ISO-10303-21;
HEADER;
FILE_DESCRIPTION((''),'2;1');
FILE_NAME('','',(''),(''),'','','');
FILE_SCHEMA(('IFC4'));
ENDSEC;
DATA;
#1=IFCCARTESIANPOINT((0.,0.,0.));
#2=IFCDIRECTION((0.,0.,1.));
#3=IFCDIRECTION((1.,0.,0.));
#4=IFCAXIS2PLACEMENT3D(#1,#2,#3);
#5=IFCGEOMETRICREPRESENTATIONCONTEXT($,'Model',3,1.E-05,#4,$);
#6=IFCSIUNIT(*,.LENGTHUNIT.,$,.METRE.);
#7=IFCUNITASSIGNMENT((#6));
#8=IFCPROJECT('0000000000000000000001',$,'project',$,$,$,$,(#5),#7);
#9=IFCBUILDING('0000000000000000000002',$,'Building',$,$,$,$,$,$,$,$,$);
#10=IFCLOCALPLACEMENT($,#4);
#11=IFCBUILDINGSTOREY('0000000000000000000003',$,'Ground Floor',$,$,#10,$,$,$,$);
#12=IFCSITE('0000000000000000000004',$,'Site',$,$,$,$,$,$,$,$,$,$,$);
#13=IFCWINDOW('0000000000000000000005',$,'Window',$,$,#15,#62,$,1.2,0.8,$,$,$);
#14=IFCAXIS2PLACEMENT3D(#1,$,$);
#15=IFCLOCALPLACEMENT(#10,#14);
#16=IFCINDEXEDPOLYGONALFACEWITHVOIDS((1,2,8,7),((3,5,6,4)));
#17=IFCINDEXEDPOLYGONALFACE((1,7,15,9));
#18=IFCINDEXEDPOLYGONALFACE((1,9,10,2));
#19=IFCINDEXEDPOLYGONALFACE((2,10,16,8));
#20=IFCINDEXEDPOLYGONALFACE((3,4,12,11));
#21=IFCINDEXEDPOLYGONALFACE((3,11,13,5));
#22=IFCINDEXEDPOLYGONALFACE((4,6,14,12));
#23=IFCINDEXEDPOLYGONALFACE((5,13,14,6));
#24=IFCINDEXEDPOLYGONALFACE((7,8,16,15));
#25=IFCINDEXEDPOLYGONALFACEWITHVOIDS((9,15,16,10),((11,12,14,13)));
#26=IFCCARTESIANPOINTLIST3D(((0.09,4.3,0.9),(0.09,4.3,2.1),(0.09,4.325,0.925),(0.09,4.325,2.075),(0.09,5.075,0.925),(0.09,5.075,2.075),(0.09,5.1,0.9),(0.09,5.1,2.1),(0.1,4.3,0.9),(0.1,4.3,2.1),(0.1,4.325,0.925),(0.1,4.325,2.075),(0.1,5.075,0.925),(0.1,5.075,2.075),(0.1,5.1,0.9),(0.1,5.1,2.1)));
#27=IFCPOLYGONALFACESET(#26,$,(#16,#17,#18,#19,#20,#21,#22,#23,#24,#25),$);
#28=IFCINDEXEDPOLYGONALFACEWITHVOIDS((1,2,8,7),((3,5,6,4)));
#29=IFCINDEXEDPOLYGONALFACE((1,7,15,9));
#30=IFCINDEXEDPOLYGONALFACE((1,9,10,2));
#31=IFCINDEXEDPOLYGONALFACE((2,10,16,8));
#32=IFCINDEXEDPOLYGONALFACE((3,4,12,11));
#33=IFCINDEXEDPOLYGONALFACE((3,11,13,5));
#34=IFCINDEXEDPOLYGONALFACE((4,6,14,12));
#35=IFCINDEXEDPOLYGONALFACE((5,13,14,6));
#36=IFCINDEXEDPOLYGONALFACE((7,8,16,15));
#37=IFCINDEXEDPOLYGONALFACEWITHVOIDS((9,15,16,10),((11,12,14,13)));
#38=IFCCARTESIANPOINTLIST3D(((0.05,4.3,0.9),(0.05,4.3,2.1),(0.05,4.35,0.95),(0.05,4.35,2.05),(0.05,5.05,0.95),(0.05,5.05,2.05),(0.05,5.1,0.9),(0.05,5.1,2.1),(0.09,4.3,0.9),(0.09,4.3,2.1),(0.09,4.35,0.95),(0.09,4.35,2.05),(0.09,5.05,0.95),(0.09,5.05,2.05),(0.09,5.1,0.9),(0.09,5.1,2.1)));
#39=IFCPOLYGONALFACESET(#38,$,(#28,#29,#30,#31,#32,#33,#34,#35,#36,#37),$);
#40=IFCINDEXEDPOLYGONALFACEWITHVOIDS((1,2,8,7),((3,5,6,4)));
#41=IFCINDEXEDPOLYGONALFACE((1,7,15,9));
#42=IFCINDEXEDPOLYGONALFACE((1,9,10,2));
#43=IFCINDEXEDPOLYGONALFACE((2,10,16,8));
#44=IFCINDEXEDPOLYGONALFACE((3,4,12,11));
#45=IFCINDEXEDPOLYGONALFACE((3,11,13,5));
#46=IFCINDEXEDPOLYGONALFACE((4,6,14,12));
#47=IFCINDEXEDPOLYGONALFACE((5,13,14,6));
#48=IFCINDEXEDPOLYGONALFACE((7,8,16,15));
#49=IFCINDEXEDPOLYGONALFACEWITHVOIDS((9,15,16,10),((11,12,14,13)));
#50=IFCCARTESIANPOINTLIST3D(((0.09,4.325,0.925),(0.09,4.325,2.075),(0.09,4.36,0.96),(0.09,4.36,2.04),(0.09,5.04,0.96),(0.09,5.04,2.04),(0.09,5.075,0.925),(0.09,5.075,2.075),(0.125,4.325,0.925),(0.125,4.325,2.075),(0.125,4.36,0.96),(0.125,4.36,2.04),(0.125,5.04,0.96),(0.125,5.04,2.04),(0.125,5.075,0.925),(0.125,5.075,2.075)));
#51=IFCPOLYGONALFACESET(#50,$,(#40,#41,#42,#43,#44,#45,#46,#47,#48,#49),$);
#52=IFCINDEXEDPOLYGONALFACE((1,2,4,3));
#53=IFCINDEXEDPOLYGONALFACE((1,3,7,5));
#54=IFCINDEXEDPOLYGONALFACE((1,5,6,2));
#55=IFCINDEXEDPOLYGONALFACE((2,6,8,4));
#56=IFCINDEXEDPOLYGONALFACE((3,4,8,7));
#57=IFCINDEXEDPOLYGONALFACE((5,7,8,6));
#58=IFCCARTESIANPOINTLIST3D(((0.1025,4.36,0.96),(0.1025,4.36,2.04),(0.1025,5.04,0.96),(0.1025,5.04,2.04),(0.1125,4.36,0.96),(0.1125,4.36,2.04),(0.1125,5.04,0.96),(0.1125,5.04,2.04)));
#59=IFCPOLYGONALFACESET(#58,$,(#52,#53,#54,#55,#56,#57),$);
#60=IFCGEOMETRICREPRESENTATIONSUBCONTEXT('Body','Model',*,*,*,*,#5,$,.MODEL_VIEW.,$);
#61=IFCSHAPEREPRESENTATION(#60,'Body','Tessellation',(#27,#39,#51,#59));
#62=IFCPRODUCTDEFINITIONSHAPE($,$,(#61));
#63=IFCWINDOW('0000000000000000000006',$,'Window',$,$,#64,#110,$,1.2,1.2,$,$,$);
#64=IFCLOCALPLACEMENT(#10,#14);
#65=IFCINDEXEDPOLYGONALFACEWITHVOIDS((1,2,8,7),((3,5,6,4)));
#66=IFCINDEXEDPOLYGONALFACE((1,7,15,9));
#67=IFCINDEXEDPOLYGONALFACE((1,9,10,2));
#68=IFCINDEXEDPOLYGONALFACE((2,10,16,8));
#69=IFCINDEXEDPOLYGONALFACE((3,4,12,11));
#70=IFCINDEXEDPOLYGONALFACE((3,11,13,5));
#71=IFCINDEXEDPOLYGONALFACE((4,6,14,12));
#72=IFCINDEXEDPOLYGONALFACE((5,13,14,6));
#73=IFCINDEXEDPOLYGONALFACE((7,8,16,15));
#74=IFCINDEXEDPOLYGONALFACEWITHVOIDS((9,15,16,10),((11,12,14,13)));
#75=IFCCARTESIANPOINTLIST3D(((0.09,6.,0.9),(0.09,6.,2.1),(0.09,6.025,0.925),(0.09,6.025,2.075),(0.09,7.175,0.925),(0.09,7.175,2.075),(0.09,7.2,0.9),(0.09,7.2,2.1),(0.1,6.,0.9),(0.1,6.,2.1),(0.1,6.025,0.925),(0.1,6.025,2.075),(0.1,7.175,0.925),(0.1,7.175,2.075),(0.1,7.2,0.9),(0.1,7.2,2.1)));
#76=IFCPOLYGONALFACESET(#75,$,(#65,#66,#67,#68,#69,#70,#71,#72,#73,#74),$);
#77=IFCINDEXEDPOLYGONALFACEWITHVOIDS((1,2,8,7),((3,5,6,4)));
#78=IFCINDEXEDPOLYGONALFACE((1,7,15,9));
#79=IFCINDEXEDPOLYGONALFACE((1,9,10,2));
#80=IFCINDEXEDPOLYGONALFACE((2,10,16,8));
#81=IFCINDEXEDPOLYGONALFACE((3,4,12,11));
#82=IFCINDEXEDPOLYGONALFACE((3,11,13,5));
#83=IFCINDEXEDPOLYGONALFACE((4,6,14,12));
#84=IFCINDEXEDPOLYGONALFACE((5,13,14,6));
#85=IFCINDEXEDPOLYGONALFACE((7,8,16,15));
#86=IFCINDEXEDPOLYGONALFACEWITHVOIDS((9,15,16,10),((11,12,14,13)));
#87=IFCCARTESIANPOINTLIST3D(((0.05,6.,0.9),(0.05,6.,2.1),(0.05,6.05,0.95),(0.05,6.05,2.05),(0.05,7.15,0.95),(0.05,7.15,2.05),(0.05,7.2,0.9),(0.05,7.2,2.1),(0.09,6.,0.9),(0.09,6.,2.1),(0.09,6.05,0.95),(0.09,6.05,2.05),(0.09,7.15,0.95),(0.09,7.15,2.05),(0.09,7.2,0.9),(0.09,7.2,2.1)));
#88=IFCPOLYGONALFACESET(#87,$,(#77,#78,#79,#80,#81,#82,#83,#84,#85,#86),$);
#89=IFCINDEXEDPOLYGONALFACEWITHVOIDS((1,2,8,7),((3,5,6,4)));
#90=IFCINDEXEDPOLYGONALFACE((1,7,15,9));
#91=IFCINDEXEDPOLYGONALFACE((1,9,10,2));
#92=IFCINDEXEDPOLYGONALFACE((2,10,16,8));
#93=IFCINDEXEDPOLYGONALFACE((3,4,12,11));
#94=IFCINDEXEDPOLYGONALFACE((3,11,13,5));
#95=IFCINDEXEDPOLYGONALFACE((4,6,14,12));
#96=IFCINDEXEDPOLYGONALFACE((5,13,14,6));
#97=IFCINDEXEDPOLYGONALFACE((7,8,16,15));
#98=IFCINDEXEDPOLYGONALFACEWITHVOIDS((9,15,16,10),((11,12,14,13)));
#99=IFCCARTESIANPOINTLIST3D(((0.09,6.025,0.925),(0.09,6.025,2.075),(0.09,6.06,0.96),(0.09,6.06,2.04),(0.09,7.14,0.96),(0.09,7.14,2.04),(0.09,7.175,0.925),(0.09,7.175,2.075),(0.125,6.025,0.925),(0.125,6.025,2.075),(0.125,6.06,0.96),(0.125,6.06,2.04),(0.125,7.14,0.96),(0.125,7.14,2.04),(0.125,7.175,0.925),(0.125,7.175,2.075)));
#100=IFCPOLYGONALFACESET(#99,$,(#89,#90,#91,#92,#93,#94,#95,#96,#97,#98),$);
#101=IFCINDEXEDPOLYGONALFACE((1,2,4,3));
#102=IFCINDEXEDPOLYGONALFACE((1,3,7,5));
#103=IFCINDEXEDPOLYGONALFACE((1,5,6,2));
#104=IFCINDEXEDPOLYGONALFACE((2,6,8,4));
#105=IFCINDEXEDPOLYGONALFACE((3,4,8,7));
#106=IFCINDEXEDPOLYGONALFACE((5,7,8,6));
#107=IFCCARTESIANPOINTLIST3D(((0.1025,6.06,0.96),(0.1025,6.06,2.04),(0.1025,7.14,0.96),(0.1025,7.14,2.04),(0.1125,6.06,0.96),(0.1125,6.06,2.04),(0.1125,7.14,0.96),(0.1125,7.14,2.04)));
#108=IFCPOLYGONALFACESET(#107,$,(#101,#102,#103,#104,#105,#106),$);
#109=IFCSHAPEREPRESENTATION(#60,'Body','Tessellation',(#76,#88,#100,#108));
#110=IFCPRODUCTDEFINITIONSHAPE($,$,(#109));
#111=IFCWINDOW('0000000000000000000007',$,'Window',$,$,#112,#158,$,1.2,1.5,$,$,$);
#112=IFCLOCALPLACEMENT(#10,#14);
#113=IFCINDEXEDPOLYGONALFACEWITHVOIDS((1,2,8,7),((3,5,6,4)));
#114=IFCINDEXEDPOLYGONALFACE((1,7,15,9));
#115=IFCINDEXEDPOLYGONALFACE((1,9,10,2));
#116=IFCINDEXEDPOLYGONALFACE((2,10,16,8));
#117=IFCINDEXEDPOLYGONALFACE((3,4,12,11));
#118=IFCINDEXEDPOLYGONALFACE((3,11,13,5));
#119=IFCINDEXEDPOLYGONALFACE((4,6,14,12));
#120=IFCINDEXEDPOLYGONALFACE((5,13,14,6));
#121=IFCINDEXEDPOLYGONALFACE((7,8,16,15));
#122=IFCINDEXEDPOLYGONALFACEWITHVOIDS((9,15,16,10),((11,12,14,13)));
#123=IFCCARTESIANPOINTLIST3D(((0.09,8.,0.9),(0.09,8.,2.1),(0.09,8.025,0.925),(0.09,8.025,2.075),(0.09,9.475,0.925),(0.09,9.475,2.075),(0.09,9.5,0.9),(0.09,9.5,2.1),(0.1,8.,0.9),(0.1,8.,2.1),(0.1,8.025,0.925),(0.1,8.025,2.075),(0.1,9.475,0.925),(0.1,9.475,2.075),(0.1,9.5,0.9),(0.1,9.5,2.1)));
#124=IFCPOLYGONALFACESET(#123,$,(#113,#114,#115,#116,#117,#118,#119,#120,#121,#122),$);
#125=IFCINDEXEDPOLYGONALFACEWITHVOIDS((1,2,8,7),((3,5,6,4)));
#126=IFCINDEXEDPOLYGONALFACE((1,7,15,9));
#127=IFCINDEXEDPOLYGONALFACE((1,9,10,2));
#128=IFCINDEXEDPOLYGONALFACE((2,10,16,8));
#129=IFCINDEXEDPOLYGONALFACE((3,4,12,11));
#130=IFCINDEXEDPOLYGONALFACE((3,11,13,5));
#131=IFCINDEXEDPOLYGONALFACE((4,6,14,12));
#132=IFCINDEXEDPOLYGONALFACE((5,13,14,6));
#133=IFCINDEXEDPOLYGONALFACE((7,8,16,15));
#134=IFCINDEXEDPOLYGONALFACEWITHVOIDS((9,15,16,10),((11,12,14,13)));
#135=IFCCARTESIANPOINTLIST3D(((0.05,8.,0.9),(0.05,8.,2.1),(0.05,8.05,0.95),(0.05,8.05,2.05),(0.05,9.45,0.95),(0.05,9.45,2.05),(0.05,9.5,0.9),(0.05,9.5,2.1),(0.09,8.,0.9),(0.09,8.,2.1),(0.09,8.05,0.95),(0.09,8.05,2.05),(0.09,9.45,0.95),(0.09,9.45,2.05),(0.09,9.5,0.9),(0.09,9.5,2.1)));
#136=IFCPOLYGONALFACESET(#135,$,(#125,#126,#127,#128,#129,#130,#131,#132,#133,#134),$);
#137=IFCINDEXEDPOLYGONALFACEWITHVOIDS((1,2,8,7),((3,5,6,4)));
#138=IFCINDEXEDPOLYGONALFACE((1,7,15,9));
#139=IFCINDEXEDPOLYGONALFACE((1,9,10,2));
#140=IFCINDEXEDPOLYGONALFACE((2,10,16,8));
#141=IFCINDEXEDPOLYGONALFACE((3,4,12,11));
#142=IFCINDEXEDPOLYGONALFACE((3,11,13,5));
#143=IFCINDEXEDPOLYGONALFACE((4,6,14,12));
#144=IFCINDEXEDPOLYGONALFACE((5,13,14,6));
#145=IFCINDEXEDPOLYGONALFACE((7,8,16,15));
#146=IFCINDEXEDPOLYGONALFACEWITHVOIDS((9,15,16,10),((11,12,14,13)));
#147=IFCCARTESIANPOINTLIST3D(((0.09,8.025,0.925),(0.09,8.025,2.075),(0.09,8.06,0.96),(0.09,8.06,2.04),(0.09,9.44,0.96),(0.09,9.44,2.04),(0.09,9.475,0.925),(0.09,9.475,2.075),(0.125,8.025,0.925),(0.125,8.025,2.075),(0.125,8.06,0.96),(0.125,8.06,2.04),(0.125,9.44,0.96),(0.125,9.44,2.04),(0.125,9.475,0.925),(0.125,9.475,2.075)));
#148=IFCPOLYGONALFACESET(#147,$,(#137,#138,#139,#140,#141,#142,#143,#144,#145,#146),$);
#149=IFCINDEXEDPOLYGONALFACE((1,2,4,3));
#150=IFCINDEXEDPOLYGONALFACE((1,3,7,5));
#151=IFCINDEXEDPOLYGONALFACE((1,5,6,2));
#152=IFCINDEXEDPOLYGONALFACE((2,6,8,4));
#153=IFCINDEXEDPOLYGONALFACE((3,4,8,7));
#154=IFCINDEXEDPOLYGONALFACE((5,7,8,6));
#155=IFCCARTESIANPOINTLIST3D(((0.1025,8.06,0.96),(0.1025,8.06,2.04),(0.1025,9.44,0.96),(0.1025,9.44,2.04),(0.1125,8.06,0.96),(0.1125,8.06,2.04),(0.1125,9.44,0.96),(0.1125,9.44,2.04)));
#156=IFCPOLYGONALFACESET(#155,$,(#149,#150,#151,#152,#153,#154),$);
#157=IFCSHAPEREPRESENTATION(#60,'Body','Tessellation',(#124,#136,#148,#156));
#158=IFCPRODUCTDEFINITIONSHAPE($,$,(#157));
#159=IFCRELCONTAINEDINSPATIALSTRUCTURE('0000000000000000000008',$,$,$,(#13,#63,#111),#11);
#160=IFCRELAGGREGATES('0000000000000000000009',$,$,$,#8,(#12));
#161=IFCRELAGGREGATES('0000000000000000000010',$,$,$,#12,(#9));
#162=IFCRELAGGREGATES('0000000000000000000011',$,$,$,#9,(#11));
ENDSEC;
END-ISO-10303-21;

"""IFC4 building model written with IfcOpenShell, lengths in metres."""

from ifc_helpers import new_model, si_unit, frame, origin_with_axes, place, context, subcontext, project, spatial, line, indexed_curve, outline, extrude, element, save


model = new_model("IFC4")

# Units and contexts
model_context = context("Model", 3, precision=1e-05, world=origin_with_axes())
body_context = subcontext(model_context, "Body", "Model", "MODEL_VIEW")
ifc_project = project(units=[si_unit("LENGTHUNIT", "METRE")], contexts=[model_context])

# Site, building, storey
site = spatial("IfcSite", under=ifc_project, Name="Site")
building = spatial("IfcBuilding", under=site, Name="Building")
storey_placement = place(None, origin_with_axes())
storey = spatial("IfcBuildingStorey", under=building, at=storey_placement, Name="Ground Floor")

# Windows
window_1_placement = place(storey_placement, frame((0.0, 5.1, 0.9), z_axis=(0.0, 0.0, 1.0), x_axis=(0.0, -1.0, 0.0)))
element("IfcWindow", 1, at=window_1_placement, inside=storey, Name="Window", OverallHeight=1.2, OverallWidth=0.8, context=body_context, shape_type="SweptSolid", body=[
    extrude(outline(indexed_curve([(0.0, 0.0), (0.8, 0.0), (0.8, 1.2), (0.0, 1.2)], segments=[line(1, 2, 3, 4, 1)]), holes=[indexed_curve([(0.025, 0.025), (0.775, 0.025), (0.775, 1.175), (0.025, 1.175)], segments=[line(1, 2, 3, 4, 1)])]), frame((0.0, 0.09, 0.0), z_axis=(0.0, -1.0, 0.0), x_axis=(1.0, 0.0, 0.0)), (0.0, 0.0, -1.0), 0.01),
    extrude(outline(indexed_curve([(0.0, 0.0), (0.8, 0.0), (0.8, 1.2), (0.0, 1.2)], segments=[line(1, 2, 3, 4, 1)]), holes=[indexed_curve([(0.05, 0.05), (0.75, 0.05), (0.75, 1.15), (0.05, 1.15)], segments=[line(1, 2, 3, 4, 1)])]), frame((0.0, 0.05, 0.0), z_axis=(0.0, -1.0, 0.0), x_axis=(1.0, 0.0, 0.0)), (0.0, 0.0, -1.0), 0.04),
    extrude(outline(indexed_curve([(0.0, 0.0), (0.75, 0.0), (0.75, 1.15), (0.0, 1.15)], segments=[line(1, 2, 3, 4, 1)]), holes=[indexed_curve([(0.035, 0.035), (0.715, 0.035), (0.715, 1.115), (0.035, 1.115)], segments=[line(1, 2, 3, 4, 1)])]), frame((0.025, 0.09, 0.025), z_axis=(0.0, -1.0, 0.0), x_axis=(1.0, 0.0, 0.0)), (0.0, 0.0, -1.0), 0.035),
    extrude(outline(indexed_curve([(0.035, 0.035), (0.715, 0.035), (0.715, 1.115), (0.035, 1.115)], segments=[line(1, 2, 3, 4, 1)])), frame((0.025, 0.1025, 0.025), z_axis=(0.0, -1.0, 0.0), x_axis=(1.0, 0.0, 0.0)), (0.0, 0.0, -1.0), 0.01),
])
window_2_placement = place(storey_placement, frame((0.0, 7.2, 0.9), z_axis=(0.0, 0.0, 1.0), x_axis=(0.0, -1.0, 0.0)))
element("IfcWindow", 2, at=window_2_placement, inside=storey, Name="Window", OverallHeight=1.2, OverallWidth=1.2, context=body_context, shape_type="SweptSolid", body=[
    extrude(outline(indexed_curve([(0.0, 0.0), (1.2, 0.0), (1.2, 1.2), (0.0, 1.2)], segments=[line(1, 2, 3, 4, 1)]), holes=[indexed_curve([(0.025, 0.025), (1.175, 0.025), (1.175, 1.175), (0.025, 1.175)], segments=[line(1, 2, 3, 4, 1)])]), frame((0.0, 0.09, 0.0), z_axis=(0.0, -1.0, 0.0), x_axis=(1.0, 0.0, 0.0)), (0.0, 0.0, -1.0), 0.01),
    extrude(outline(indexed_curve([(0.0, 0.0), (1.2, 0.0), (1.2, 1.2), (0.0, 1.2)], segments=[line(1, 2, 3, 4, 1)]), holes=[indexed_curve([(0.05, 0.05), (1.15, 0.05), (1.15, 1.15), (0.05, 1.15)], segments=[line(1, 2, 3, 4, 1)])]), frame((0.0, 0.05, 0.0), z_axis=(0.0, -1.0, 0.0), x_axis=(1.0, 0.0, 0.0)), (0.0, 0.0, -1.0), 0.04),
    extrude(outline(indexed_curve([(0.0, 0.0), (1.15, 0.0), (1.15, 1.15), (0.0, 1.15)], segments=[line(1, 2, 3, 4, 1)]), holes=[indexed_curve([(0.035, 0.035), (1.115, 0.035), (1.115, 1.115), (0.035, 1.115)], segments=[line(1, 2, 3, 4, 1)])]), frame((0.025, 0.09, 0.025), z_axis=(0.0, -1.0, 0.0), x_axis=(1.0, 0.0, 0.0)), (0.0, 0.0, -1.0), 0.035),
    extrude(outline(indexed_curve([(0.035, 0.035), (1.115, 0.035), (1.115, 1.115), (0.035, 1.115)], segments=[line(1, 2, 3, 4, 1)])), frame((0.025, 0.1025, 0.025), z_axis=(0.0, -1.0, 0.0), x_axis=(1.0, 0.0, 0.0)), (0.0, 0.0, -1.0), 0.01),
])
window_3_placement = place(storey_placement, frame((0.0, 9.5, 0.9), z_axis=(0.0, 0.0, 1.0), x_axis=(0.0, -1.0, 0.0)))
element("IfcWindow", 3, at=window_3_placement, inside=storey, Name="Window", OverallHeight=1.2, OverallWidth=1.5, context=body_context, shape_type="SweptSolid", body=[
    extrude(outline(indexed_curve([(0.0, 0.0), (1.5, 0.0), (1.5, 1.2), (0.0, 1.2)], segments=[line(1, 2, 3, 4, 1)]), holes=[indexed_curve([(0.025, 0.025), (1.475, 0.025), (1.475, 1.175), (0.025, 1.175)], segments=[line(1, 2, 3, 4, 1)])]), frame((0.0, 0.09, 0.0), z_axis=(0.0, -1.0, 0.0), x_axis=(1.0, 0.0, 0.0)), (0.0, 0.0, -1.0), 0.01),
    extrude(outline(indexed_curve([(0.0, 0.0), (1.5, 0.0), (1.5, 1.2), (0.0, 1.2)], segments=[line(1, 2, 3, 4, 1)]), holes=[indexed_curve([(0.05, 0.05), (1.45, 0.05), (1.45, 1.15), (0.05, 1.15)], segments=[line(1, 2, 3, 4, 1)])]), frame((0.0, 0.05, 0.0), z_axis=(0.0, -1.0, 0.0), x_axis=(1.0, 0.0, 0.0)), (0.0, 0.0, -1.0), 0.04),
    extrude(outline(indexed_curve([(0.0, 0.0), (1.45, 0.0), (1.45, 1.15), (0.0, 1.15)], segments=[line(1, 2, 3, 4, 1)]), holes=[indexed_curve([(0.035, 0.035), (1.415, 0.035), (1.415, 1.115), (0.035, 1.115)], segments=[line(1, 2, 3, 4, 1)])]), frame((0.025, 0.09, 0.025), z_axis=(0.0, -1.0, 0.0), x_axis=(1.0, 0.0, 0.0)), (0.0, 0.0, -1.0), 0.035),
    extrude(outline(indexed_curve([(0.035, 0.035), (1.415, 0.035), (1.415, 1.115), (0.035, 1.115)], segments=[line(1, 2, 3, 4, 1)])), frame((0.025, 0.1025, 0.025), z_axis=(0.0, -1.0, 0.0), x_axis=(1.0, 0.0, 0.0)), (0.0, 0.0, -1.0), 0.01),
])

save(model, "model.ifc")
